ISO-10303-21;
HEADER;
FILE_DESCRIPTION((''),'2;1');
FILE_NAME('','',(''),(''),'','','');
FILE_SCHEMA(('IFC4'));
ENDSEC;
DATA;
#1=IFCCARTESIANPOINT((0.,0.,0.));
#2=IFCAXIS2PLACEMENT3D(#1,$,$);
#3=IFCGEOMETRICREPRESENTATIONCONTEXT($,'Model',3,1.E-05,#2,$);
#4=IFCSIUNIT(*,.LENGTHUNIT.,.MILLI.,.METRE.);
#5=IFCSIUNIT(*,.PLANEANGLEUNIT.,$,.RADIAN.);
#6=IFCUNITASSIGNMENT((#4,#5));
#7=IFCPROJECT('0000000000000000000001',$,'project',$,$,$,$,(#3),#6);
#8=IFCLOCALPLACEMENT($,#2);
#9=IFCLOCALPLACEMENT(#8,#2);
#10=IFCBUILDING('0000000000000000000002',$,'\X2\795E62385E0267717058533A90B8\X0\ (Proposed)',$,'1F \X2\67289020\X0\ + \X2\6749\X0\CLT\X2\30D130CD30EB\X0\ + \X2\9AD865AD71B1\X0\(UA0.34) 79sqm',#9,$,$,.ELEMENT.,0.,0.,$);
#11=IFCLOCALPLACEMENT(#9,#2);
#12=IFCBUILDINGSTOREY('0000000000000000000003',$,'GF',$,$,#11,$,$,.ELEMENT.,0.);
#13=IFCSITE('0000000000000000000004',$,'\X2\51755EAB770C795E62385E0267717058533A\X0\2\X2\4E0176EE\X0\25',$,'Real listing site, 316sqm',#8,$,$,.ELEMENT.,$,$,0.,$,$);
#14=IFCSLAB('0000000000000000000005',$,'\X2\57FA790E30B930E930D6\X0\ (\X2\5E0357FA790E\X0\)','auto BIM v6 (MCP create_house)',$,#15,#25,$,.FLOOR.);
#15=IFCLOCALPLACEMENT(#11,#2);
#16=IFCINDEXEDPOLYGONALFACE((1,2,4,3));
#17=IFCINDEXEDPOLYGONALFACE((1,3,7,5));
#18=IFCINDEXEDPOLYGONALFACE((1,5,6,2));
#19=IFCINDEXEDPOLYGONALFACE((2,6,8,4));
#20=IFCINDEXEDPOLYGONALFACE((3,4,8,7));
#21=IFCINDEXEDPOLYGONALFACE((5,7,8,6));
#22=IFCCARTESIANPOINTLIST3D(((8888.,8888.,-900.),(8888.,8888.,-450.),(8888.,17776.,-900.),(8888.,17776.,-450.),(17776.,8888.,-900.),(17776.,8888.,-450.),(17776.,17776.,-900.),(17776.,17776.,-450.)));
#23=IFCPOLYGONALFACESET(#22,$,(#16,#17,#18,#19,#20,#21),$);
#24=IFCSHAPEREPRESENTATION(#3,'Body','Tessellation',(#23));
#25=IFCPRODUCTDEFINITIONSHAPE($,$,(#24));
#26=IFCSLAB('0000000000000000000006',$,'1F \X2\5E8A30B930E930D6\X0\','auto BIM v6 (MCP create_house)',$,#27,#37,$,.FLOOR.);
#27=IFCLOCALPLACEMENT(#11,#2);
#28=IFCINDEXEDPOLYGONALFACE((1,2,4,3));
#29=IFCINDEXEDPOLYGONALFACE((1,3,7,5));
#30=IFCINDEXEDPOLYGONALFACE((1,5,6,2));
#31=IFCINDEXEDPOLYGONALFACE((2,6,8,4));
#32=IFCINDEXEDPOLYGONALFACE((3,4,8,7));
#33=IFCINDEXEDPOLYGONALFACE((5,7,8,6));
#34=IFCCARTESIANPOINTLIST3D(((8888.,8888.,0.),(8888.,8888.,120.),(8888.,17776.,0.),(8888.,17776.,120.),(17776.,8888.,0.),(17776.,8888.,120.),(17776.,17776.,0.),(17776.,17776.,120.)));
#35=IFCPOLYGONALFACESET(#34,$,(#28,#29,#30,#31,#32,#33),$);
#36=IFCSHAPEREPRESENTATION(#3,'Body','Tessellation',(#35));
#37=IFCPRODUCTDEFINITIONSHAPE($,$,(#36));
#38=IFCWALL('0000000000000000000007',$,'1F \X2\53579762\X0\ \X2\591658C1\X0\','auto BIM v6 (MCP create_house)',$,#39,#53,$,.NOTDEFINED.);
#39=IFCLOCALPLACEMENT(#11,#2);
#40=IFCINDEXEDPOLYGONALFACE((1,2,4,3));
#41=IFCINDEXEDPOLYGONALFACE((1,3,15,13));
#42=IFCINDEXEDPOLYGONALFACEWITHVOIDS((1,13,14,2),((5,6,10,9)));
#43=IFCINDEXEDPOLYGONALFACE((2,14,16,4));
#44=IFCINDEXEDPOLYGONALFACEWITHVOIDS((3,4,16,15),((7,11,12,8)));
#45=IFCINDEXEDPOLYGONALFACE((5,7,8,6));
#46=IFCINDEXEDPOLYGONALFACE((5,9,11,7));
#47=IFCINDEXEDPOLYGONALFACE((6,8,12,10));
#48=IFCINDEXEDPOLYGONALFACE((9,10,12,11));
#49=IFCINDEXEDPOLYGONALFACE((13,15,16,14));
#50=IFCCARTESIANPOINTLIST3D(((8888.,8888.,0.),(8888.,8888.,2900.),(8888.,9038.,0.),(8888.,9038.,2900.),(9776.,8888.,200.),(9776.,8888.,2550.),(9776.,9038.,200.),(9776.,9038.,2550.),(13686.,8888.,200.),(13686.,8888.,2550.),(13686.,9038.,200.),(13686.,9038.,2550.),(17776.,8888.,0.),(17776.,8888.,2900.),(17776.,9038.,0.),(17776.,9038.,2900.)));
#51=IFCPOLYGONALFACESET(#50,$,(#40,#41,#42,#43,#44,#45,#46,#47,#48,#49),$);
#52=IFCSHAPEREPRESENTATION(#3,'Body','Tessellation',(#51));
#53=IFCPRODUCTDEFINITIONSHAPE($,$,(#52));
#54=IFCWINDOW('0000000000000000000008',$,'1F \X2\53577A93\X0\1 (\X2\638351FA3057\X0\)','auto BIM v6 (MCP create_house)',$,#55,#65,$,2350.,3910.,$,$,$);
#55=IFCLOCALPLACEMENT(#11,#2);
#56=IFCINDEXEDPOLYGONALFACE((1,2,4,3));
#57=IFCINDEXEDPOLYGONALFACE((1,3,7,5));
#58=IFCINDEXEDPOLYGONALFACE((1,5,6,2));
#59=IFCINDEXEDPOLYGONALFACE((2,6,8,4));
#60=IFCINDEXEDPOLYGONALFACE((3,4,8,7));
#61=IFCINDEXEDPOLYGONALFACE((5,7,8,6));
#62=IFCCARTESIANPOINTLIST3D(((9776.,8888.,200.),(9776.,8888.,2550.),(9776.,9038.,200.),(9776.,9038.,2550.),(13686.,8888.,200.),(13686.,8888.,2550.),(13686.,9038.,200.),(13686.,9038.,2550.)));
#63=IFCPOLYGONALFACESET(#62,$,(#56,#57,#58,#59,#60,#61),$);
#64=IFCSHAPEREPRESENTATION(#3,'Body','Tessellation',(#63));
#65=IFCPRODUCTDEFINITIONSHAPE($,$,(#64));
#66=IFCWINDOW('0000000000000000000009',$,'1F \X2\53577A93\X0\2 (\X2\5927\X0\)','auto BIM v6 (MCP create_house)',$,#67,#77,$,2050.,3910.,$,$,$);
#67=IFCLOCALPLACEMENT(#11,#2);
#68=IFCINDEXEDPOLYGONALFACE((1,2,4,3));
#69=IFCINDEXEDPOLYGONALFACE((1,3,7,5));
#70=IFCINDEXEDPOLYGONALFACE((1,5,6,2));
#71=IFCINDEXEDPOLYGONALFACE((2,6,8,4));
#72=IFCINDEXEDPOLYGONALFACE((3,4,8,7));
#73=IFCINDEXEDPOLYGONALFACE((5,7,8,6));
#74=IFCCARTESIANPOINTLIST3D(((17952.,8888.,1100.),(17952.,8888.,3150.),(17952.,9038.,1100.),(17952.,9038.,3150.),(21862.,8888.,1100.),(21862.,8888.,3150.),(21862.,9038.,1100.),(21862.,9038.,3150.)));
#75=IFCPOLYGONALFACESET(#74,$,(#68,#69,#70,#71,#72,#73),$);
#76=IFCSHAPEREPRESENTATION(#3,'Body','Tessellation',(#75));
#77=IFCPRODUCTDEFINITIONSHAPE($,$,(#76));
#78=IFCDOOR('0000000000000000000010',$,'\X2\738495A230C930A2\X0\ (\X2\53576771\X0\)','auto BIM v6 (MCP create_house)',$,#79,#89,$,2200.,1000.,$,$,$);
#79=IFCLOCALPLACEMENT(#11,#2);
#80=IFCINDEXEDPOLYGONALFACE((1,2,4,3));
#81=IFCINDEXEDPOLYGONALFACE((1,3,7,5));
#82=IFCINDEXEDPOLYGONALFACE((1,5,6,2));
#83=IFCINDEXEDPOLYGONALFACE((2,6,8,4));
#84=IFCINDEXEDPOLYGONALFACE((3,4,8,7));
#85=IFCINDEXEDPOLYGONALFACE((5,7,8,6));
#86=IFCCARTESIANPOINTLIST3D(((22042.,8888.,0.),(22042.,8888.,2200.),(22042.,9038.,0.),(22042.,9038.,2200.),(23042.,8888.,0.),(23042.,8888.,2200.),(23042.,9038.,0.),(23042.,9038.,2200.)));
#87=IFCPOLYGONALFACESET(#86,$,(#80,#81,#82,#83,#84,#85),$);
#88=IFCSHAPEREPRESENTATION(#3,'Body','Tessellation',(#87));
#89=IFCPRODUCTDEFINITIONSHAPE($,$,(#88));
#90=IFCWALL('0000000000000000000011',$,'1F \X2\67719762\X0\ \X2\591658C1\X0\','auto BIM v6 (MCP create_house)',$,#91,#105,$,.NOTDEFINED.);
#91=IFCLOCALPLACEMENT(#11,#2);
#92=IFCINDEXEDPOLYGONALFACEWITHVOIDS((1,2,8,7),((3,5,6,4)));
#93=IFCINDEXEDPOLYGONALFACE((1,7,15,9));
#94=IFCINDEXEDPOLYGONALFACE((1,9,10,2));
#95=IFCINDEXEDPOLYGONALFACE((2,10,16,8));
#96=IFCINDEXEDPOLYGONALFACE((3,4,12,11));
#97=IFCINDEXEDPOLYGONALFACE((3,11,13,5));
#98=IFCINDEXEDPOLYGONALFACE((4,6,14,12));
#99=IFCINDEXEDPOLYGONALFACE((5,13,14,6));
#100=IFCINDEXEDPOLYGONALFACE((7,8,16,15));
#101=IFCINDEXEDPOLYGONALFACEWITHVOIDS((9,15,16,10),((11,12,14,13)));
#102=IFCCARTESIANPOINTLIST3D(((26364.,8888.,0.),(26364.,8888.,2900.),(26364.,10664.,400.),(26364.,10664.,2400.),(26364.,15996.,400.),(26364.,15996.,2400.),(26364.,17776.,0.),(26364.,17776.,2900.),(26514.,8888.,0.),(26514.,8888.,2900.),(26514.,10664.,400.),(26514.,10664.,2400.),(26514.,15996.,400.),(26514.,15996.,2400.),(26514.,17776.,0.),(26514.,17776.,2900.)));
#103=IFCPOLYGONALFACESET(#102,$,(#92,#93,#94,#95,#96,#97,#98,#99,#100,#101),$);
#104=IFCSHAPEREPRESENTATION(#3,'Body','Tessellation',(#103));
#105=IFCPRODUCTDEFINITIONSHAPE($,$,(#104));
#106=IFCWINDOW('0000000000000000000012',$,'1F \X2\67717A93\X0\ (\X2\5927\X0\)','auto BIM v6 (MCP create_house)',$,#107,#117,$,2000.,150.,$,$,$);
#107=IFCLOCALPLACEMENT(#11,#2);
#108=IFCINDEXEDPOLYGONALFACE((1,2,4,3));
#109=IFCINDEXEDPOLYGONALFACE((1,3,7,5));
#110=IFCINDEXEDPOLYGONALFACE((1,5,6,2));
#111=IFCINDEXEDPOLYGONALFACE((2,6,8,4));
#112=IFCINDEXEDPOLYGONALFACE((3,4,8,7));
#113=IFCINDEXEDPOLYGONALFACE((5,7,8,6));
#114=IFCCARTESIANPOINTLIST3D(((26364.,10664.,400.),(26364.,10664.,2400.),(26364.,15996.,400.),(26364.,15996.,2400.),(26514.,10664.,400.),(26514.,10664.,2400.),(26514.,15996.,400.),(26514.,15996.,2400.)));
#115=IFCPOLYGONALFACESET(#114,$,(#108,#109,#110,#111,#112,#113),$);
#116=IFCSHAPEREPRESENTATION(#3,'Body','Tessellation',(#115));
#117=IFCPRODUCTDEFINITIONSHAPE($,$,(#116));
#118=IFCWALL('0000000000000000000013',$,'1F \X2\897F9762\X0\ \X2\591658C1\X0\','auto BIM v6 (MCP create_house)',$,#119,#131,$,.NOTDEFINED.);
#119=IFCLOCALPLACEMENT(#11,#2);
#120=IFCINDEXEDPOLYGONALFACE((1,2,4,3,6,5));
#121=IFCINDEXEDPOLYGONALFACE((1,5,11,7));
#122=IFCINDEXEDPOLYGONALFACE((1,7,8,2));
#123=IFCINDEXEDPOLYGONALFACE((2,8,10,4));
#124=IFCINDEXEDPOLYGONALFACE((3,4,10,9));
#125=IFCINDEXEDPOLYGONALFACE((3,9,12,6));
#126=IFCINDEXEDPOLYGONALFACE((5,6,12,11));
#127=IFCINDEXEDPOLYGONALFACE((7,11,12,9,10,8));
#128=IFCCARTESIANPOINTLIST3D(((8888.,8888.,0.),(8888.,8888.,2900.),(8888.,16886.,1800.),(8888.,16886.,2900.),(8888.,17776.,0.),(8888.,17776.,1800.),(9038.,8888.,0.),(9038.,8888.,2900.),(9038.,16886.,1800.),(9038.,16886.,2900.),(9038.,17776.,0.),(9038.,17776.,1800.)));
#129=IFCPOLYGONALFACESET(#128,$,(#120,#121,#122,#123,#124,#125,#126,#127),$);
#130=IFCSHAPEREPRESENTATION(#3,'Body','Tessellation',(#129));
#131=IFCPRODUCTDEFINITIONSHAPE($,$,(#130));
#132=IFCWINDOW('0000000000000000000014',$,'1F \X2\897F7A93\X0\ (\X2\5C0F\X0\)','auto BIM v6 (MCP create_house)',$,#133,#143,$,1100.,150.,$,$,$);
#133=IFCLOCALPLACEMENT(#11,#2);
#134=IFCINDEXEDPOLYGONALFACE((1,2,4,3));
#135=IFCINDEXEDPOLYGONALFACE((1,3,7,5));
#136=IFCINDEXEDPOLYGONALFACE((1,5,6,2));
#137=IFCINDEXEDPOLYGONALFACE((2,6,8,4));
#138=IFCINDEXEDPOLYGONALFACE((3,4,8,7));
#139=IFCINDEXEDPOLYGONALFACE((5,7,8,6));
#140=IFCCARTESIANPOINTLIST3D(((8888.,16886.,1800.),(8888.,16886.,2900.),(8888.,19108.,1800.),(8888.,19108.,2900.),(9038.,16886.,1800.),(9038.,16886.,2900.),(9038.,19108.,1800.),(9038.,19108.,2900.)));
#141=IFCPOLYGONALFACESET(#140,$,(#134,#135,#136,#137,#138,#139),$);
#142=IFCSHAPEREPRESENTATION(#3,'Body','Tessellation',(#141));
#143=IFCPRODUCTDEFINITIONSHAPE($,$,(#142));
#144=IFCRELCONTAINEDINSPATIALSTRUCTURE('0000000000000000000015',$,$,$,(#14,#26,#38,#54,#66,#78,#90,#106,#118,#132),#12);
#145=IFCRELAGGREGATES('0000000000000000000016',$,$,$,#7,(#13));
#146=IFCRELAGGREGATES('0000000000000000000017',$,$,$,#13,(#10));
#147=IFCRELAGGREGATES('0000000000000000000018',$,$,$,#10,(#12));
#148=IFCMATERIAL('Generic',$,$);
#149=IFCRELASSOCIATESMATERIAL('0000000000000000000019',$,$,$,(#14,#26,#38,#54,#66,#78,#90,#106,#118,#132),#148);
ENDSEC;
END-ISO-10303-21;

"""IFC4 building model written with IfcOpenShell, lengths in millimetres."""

from ifc_helpers import new_model, si_unit, frame, frame_2d, origin, place, context, project, spatial, rectangle, extrude, material, element, fill, save


model = new_model("IFC4")

# Units and contexts
model_context = context("Model", 3, precision=1e-05, world=origin())
ifc_project = project(units=[si_unit("LENGTHUNIT", "METRE", prefix="MILLI"), si_unit("PLANEANGLEUNIT", "RADIAN")], contexts=[model_context])

# Site, building, storey
site_placement = place(None, origin())
site = spatial("IfcSite", under=ifc_project, at=site_placement, Name="兵庫県神戸市東灘区2丁目25", ObjectType="Real listing site, 316sqm", CompositionType="ELEMENT", RefElevation=0.0)
building_placement = place(site_placement, origin())
building = spatial("IfcBuilding", under=site, at=building_placement, Name="神戸市東灘区邸 (Proposed)", ObjectType="1F 木造 + 杉CLTパネル + 高断熱(UA0.34) 79sqm", CompositionType="ELEMENT", ElevationOfRefHeight=0.0, ElevationOfTerrain=0.0)
storey_placement = place(building_placement, origin())
storey = spatial("IfcBuildingStorey", under=building, at=storey_placement, Name="GF", CompositionType="ELEMENT", Elevation=0.0)

# Slabs
ifc_material = material(Name="Generic")
slab_1_placement = place(storey_placement, frame((4444.0, 4444.0, -450.0)))
element("IfcSlab", 1, at=slab_1_placement, inside=storey, material=ifc_material, Name="基礎スラブ (布基礎)", Description="auto BIM v6 (MCP create_house)", PredefinedType="FLOOR", context=model_context, shape_type="SweptSolid", body=[
    extrude(rectangle(XDim=8888.0, YDim=8888.0, at=frame_2d((4444.0, 4444.0))), frame((4444.0, 4444.0, -450.0)), (0.0, 0.0, 1.0), 450.0),
])
slab_2_placement = place(storey_placement, frame((4444.0, 4444.0, 0.0)))
element("IfcSlab", 2, at=slab_2_placement, inside=storey, material=ifc_material, Name="1F 床スラブ", Description="auto BIM v6 (MCP create_house)", PredefinedType="FLOOR", context=model_context, shape_type="SweptSolid", body=[
    extrude(rectangle(XDim=8888.0, YDim=8888.0, at=frame_2d((4444.0, 4444.0))), frame((4444.0, 4444.0, 0.0)), (0.0, 0.0, 1.0), 120.0),
])

# Wall, openings, windows, door
wall_1_placement = place(storey_placement, frame((4444.0, 4444.0, 0.0)))
wall_1 = element("IfcWall", 3, at=wall_1_placement, inside=storey, material=ifc_material, Name="1F 南面 外壁", Description="auto BIM v6 (MCP create_house)", PredefinedType="NOTDEFINED", context=model_context, shape_type="SweptSolid", body=[
    extrude(rectangle(XDim=8888.0, YDim=150.0, at=frame_2d((4444.0, 75.0))), frame((4444.0, 4444.0, 0.0)), (0.0, 0.0, 1.0), 2900.0),
])
opening_1_placement = place(storey_placement, frame((4888.0, 4444.0, 100.0)))
opening_1 = element("IfcOpeningElement", 4, at=opening_1_placement, cuts=wall_1, PredefinedType="NOTDEFINED", context=model_context, shape_type="SweptSolid", body=[
    extrude(rectangle(XDim=3910.0, YDim=150.0, at=frame_2d((1955.0, 75.0))), frame((4888.0, 4444.0, 100.0)), (0.0, 0.0, 1.0), 2350.0),
])
opening_2_placement = place(storey_placement, frame((8976.0, 4444.0, 550.0)))
opening_2 = element("IfcOpeningElement", 5, at=opening_2_placement, cuts=wall_1, PredefinedType="NOTDEFINED", context=model_context, shape_type="SweptSolid", body=[
    extrude(rectangle(XDim=3910.0, YDim=150.0, at=frame_2d((1955.0, 75.0))), frame((8976.0, 4444.0, 550.0)), (0.0, 0.0, 1.0), 2050.0),
])
opening_3_placement = place(storey_placement, frame((11021.0, 4444.0, 0.0)))
opening_3 = element("IfcOpeningElement", 6, at=opening_3_placement, cuts=wall_1, PredefinedType="NOTDEFINED", context=model_context, shape_type="SweptSolid", body=[
    extrude(rectangle(XDim=1000.0, YDim=150.0, at=frame_2d((500.0, 75.0))), frame((11021.0, 4444.0, 0.0)), (0.0, 0.0, 1.0), 2200.0),
])
window_1_placement = place(storey_placement, frame((4888.0, 4444.0, 100.0)))
window_1 = element("IfcWindow", 7, at=window_1_placement, inside=storey, material=ifc_material, Name="1F 南窓1 (掃出し)", Description="auto BIM v6 (MCP create_house)", OverallHeight=2350.0, OverallWidth=3910.0, context=model_context, shape_type="SweptSolid", body=[
    extrude(rectangle(XDim=3910.0, YDim=150.0, at=frame_2d((1955.0, 75.0))), frame((4888.0, 4444.0, 100.0)), (0.0, 0.0, 1.0), 2350.0),
])
fill(opening_1, window_1)
window_2_placement = place(storey_placement, frame((8976.0, 4444.0, 550.0)))
window_2 = element("IfcWindow", 8, at=window_2_placement, inside=storey, material=ifc_material, Name="1F 南窓2 (大)", Description="auto BIM v6 (MCP create_house)", OverallHeight=2050.0, OverallWidth=3910.0, context=model_context, shape_type="SweptSolid", body=[
    extrude(rectangle(XDim=3910.0, YDim=150.0, at=frame_2d((1955.0, 75.0))), frame((8976.0, 4444.0, 550.0)), (0.0, 0.0, 1.0), 2050.0),
])
fill(opening_2, window_2)
door_placement = place(storey_placement, frame((11021.0, 4444.0, 0.0)))
door = element("IfcDoor", 9, at=door_placement, inside=storey, material=ifc_material, Name="玄関ドア (南東)", Description="auto BIM v6 (MCP create_house)", OverallHeight=2200.0, OverallWidth=1000.0, context=model_context, shape_type="SweptSolid", body=[
    extrude(rectangle(XDim=1000.0, YDim=150.0, at=frame_2d((500.0, 75.0))), frame((11021.0, 4444.0, 0.0)), (0.0, 0.0, 1.0), 2200.0),
])
fill(opening_3, door)

# Walls, openings, windows
wall_2_placement = place(storey_placement, frame((13182.0, 4444.0, 0.0)))
wall_2 = element("IfcWall", 10, at=wall_2_placement, inside=storey, material=ifc_material, Name="1F 東面 外壁", Description="auto BIM v6 (MCP create_house)", PredefinedType="NOTDEFINED", context=model_context, shape_type="SweptSolid", body=[
    extrude(rectangle(XDim=150.0, YDim=8888.0, at=frame_2d((75.0, 4444.0))), frame((13182.0, 4444.0, 0.0)), (0.0, 0.0, 1.0), 2900.0),
])
opening_4_placement = place(storey_placement, frame((13182.0, 5332.0, 200.0)))
opening_4 = element("IfcOpeningElement", 11, at=opening_4_placement, cuts=wall_2, PredefinedType="NOTDEFINED", context=model_context, shape_type="SweptSolid", body=[
    extrude(rectangle(XDim=150.0, YDim=5332.0, at=frame_2d((75.0, 2666.0))), frame((13182.0, 5332.0, 200.0)), (0.0, 0.0, 1.0), 2000.0),
])
window_3_placement = place(storey_placement, frame((13182.0, 5332.0, 200.0)))
window_3 = element("IfcWindow", 12, at=window_3_placement, inside=storey, material=ifc_material, Name="1F 東窓 (大)", Description="auto BIM v6 (MCP create_house)", OverallHeight=2000.0, OverallWidth=150.0, context=model_context, shape_type="SweptSolid", body=[
    extrude(rectangle(XDim=150.0, YDim=5332.0, at=frame_2d((75.0, 2666.0))), frame((13182.0, 5332.0, 200.0)), (0.0, 0.0, 1.0), 2000.0),
])
fill(opening_4, window_3)
wall_3_placement = place(storey_placement, frame((4444.0, 4444.0, 0.0)))
wall_3 = element("IfcWall", 13, at=wall_3_placement, inside=storey, material=ifc_material, Name="1F 西面 外壁", Description="auto BIM v6 (MCP create_house)", PredefinedType="NOTDEFINED", context=model_context, shape_type="SweptSolid", body=[
    extrude(rectangle(XDim=150.0, YDim=8888.0, at=frame_2d((75.0, 4444.0))), frame((4444.0, 4444.0, 0.0)), (0.0, 0.0, 1.0), 2900.0),
])
opening_5_placement = place(storey_placement, frame((4444.0, 8443.0, 900.0)))
opening_5 = element("IfcOpeningElement", 14, at=opening_5_placement, cuts=wall_3, PredefinedType="NOTDEFINED", context=model_context, shape_type="SweptSolid", body=[
    extrude(rectangle(XDim=150.0, YDim=2222.0, at=frame_2d((75.0, 1111.0))), frame((4444.0, 8443.0, 900.0)), (0.0, 0.0, 1.0), 1100.0),
])
window_4_placement = place(storey_placement, frame((4444.0, 8443.0, 900.0)))
window_4 = element("IfcWindow", 15, at=window_4_placement, inside=storey, material=ifc_material, Name="1F 西窓 (小)", Description="auto BIM v6 (MCP create_house)", OverallHeight=1100.0, OverallWidth=150.0, context=model_context, shape_type="SweptSolid", body=[
    extrude(rectangle(XDim=150.0, YDim=2222.0, at=frame_2d((75.0, 1111.0))), frame((4444.0, 8443.0, 900.0)), (0.0, 0.0, 1.0), 1100.0),
])
fill(opening_5, window_4)

save(model, "model.ifc")
